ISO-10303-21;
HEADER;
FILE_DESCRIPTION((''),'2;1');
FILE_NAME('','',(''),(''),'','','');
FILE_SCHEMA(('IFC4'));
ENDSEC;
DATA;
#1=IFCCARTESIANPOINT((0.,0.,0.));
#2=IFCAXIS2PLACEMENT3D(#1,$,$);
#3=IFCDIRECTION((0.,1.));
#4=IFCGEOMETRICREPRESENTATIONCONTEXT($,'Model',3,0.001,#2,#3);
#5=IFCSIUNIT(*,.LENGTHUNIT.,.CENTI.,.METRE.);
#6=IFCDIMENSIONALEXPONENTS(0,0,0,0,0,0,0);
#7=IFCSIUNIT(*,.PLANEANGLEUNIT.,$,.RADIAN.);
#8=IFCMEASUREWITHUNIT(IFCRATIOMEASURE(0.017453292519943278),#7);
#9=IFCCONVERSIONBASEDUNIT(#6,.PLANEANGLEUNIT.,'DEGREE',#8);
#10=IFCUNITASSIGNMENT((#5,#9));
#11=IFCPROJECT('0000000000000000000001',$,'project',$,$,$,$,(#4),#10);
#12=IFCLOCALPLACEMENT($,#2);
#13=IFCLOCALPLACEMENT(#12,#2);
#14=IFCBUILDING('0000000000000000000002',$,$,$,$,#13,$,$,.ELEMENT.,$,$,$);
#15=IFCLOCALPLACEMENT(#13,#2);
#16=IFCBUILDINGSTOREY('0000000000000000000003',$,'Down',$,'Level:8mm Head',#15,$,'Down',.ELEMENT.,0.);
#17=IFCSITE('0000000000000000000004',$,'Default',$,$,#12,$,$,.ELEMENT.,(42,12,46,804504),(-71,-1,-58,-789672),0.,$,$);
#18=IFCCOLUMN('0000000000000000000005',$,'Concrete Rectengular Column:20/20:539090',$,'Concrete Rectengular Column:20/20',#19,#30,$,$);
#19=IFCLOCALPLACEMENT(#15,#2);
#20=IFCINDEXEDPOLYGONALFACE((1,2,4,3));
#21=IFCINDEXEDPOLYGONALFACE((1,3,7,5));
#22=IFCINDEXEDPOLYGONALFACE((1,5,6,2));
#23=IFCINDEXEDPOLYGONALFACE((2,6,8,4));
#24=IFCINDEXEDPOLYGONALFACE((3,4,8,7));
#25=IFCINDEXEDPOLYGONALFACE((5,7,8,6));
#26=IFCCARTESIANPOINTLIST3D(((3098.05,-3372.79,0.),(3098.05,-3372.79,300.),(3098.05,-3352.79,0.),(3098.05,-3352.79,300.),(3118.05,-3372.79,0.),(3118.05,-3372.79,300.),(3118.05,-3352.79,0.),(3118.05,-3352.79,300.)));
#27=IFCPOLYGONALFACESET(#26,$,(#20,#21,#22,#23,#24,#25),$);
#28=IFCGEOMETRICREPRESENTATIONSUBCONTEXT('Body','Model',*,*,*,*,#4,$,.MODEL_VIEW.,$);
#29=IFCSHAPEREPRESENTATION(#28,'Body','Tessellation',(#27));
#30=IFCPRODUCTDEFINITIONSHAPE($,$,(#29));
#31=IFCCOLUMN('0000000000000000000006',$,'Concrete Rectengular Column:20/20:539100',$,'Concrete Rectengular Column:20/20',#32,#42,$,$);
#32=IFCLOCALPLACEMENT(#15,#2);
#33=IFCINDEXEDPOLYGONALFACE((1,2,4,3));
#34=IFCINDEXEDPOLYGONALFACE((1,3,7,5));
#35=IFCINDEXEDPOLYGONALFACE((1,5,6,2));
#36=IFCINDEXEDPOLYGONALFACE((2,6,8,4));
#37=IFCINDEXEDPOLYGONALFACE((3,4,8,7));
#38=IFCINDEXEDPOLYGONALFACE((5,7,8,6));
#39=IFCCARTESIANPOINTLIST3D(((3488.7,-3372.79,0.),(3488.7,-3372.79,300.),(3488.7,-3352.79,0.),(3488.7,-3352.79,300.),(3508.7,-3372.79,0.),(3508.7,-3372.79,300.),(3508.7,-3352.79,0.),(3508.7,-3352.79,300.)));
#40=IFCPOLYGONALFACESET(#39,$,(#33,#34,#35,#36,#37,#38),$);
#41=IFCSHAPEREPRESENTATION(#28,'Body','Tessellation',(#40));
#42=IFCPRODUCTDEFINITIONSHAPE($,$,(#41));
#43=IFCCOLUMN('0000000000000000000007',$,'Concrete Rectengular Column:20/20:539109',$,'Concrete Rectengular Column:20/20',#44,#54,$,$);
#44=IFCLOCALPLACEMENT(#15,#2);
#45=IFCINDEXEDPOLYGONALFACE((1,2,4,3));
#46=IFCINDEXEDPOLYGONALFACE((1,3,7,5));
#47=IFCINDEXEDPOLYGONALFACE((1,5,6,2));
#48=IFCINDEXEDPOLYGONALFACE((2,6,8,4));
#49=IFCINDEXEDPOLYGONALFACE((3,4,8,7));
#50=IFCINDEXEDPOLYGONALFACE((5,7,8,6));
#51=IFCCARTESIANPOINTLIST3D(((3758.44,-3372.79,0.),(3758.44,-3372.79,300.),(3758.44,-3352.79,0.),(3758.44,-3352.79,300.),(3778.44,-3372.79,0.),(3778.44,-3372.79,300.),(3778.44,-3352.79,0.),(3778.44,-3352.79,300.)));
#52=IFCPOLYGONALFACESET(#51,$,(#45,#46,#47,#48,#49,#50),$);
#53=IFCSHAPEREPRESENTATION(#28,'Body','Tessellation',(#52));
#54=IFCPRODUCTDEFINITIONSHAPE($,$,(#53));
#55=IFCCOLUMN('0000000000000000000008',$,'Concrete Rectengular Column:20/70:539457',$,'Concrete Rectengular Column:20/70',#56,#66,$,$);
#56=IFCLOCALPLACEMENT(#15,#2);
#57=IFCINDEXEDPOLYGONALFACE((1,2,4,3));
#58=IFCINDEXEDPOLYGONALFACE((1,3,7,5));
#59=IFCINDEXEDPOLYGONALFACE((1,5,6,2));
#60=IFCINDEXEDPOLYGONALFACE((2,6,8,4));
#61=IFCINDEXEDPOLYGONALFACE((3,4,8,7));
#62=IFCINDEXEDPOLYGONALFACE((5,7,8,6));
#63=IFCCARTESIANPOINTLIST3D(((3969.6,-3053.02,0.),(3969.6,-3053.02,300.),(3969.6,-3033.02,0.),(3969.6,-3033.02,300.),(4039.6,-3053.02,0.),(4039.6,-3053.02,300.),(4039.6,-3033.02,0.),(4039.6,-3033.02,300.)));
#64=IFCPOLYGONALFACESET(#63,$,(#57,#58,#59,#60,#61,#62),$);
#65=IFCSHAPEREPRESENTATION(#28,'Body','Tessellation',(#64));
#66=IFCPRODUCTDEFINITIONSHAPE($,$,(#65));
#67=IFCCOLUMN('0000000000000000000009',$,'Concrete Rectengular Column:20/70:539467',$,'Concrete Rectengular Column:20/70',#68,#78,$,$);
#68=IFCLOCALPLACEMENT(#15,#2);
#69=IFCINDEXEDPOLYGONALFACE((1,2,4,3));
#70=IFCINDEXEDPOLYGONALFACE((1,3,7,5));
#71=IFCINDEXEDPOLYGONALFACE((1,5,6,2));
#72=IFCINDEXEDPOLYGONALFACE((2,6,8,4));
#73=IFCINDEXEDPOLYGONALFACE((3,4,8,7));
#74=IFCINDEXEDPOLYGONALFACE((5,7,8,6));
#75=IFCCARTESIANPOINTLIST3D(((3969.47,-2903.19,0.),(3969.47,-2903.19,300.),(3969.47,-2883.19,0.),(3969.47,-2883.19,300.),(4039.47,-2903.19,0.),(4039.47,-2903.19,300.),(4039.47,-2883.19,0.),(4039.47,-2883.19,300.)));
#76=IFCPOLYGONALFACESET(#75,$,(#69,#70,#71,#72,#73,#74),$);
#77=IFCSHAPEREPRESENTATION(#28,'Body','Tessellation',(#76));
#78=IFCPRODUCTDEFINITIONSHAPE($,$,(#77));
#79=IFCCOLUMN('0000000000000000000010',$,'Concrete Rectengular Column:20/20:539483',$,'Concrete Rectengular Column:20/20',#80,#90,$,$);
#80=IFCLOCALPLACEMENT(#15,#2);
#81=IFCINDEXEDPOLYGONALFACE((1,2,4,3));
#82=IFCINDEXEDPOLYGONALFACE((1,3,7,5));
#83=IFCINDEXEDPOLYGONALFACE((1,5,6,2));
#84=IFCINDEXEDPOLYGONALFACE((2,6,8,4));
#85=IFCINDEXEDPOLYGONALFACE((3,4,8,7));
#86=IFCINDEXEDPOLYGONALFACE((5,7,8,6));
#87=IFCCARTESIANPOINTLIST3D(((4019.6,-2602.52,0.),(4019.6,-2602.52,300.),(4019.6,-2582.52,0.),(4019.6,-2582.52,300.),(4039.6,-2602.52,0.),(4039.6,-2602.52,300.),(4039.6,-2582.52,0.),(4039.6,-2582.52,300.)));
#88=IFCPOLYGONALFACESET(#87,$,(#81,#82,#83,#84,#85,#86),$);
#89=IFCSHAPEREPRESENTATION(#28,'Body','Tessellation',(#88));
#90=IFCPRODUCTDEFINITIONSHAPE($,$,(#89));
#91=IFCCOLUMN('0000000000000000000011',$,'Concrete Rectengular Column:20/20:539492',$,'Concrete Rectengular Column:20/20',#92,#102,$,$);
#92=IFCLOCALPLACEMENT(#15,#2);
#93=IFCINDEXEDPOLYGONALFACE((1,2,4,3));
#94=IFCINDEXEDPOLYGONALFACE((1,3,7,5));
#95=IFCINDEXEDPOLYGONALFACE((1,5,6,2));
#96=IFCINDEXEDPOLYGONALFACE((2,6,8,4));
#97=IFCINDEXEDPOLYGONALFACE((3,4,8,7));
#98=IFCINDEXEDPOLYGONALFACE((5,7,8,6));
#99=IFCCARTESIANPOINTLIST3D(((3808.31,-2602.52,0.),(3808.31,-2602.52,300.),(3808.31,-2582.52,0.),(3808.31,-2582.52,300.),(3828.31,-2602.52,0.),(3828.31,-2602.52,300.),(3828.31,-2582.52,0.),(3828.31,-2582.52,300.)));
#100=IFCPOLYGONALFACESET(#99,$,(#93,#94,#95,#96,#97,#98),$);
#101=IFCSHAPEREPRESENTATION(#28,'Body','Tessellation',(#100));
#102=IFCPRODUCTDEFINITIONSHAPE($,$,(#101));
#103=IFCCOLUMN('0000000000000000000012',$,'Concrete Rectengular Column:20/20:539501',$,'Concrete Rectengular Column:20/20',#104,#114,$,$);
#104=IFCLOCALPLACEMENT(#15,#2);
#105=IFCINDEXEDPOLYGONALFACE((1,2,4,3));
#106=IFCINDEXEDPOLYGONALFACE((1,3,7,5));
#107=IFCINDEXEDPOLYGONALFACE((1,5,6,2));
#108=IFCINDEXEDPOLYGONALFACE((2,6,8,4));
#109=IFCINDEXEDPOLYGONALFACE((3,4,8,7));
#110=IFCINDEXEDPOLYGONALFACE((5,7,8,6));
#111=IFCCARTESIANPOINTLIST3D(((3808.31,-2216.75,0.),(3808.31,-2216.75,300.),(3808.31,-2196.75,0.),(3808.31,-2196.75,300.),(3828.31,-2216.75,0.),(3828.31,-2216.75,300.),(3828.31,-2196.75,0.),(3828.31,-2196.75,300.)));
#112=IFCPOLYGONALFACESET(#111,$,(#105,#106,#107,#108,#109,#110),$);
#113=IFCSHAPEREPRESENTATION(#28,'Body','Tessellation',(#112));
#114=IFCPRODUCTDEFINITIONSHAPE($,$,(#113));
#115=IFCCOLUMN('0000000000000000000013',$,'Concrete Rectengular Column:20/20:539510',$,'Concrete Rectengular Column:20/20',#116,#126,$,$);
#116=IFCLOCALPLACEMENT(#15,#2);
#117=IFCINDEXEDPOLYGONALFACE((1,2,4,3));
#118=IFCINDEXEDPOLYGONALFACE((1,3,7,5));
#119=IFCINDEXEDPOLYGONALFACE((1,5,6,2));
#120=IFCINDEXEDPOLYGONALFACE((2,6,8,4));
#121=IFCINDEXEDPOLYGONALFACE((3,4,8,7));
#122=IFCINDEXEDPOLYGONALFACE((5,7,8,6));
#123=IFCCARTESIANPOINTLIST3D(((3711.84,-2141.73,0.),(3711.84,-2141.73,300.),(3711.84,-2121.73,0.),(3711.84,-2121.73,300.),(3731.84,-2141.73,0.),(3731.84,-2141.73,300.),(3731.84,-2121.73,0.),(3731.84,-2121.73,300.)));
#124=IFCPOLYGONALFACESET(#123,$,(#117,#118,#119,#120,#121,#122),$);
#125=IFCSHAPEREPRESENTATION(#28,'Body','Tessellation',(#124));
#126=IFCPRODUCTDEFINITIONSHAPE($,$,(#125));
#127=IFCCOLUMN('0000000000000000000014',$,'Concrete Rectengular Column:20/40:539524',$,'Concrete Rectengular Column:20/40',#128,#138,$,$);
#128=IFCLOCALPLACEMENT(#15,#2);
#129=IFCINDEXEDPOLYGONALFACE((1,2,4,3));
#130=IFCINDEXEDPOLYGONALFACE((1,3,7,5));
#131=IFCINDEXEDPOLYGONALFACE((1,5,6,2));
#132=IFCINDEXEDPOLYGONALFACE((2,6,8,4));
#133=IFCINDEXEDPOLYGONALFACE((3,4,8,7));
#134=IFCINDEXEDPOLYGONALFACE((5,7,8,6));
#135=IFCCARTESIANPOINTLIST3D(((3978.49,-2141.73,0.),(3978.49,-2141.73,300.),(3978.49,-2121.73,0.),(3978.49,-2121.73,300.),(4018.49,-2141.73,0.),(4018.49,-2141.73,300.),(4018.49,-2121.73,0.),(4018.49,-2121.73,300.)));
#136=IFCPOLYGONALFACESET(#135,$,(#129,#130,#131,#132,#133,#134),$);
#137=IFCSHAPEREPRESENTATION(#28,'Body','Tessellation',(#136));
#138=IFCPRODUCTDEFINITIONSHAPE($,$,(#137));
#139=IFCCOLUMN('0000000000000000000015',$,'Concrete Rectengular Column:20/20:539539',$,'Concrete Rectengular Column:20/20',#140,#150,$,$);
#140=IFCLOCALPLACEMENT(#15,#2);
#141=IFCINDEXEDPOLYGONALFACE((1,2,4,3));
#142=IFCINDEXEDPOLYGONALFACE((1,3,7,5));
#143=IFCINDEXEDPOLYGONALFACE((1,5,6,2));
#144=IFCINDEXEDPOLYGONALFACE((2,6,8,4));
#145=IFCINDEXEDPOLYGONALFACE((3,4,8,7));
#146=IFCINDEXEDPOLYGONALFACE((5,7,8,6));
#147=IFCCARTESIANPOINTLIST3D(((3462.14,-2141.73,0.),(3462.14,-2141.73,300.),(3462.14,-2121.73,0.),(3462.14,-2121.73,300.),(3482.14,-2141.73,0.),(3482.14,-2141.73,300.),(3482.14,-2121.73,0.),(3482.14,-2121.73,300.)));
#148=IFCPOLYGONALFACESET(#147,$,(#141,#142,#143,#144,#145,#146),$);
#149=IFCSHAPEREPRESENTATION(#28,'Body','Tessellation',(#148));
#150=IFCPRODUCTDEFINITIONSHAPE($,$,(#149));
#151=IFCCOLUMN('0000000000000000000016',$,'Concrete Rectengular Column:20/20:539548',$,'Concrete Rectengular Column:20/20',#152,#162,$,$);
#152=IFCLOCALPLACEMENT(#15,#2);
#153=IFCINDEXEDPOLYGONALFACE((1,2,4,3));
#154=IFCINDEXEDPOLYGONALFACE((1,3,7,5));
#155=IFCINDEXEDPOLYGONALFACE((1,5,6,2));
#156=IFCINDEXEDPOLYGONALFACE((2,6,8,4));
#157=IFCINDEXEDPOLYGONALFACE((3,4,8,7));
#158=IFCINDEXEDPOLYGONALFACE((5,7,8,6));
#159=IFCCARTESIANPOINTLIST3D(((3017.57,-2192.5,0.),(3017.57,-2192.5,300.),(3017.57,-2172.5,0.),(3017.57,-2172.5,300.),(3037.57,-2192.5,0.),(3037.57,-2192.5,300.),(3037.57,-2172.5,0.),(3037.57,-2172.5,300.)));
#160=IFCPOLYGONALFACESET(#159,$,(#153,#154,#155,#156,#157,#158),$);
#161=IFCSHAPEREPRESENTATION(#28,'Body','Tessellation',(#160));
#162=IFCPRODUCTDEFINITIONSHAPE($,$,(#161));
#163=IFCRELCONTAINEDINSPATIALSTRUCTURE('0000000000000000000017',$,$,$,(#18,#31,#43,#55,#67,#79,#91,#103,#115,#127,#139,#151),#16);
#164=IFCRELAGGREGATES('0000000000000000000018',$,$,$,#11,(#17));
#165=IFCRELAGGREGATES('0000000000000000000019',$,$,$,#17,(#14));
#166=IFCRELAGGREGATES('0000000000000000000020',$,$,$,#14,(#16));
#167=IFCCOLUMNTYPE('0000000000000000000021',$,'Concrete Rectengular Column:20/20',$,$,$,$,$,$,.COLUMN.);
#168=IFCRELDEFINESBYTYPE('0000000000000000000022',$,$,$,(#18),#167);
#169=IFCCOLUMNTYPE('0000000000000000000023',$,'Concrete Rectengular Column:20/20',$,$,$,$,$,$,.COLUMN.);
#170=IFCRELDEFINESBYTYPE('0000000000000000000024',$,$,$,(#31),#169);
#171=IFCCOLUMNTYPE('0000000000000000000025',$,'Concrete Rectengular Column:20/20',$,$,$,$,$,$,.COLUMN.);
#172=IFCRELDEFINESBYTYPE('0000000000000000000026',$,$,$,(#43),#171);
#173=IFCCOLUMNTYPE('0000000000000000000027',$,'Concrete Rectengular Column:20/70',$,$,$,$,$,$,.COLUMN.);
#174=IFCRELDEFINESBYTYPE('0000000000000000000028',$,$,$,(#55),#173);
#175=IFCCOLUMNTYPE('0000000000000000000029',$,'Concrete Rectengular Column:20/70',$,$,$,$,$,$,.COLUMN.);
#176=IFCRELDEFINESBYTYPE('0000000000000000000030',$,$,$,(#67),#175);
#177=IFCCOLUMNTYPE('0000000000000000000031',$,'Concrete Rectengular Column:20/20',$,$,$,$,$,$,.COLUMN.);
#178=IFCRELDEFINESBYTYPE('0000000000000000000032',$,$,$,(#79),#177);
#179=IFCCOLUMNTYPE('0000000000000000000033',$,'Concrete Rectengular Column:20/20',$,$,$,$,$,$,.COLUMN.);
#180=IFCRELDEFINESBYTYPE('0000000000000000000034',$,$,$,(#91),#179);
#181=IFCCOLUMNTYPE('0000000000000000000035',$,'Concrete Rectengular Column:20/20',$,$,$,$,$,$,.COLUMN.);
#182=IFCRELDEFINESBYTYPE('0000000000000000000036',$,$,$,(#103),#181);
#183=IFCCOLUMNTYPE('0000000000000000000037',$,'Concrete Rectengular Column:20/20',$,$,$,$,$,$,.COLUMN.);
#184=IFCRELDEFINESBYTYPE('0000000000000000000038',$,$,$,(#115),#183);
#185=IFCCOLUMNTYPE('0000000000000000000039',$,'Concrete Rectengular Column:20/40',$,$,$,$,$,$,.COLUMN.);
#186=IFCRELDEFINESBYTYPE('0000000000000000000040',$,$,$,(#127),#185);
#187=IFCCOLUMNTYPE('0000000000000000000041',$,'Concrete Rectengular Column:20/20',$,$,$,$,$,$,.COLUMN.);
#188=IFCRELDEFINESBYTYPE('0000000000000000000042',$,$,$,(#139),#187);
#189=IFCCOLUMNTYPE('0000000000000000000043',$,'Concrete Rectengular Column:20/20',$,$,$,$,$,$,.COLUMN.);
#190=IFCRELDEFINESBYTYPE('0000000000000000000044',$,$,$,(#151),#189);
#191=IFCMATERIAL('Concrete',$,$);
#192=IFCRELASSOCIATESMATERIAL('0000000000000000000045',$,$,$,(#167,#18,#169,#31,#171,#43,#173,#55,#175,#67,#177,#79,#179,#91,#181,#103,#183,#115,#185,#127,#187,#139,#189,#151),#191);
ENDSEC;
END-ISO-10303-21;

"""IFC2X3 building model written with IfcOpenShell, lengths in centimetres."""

from ifc_helpers import new_model, entity, si_unit, converted_unit, direction, frame, frame_2d, origin, origin_2d_with_axis, place, context, subcontext, project, spatial, rectangle, extrude, source, transform, mapped, material, type_object, type_shapes, element, save


model = new_model("IFC2X3")

# Units and contexts
model_context = context("Model", 3, precision=0.001, world=origin(), true_north=direction((0.0, 1.0)))
body_context = subcontext(model_context, "Body", "Model", "MODEL_VIEW")
ifc_project = project(units=[si_unit("LENGTHUNIT", "METRE", prefix="CENTI"), converted_unit("PLANEANGLEUNIT", "DEGREE", entity("IfcRatioMeasure", 0.017453292519943278), si_unit("PLANEANGLEUNIT", "RADIAN"), dimensions=[0, 0, 0, 0, 0, 0, 0])], contexts=[model_context])

# Site, building, storey
site_placement = place(None, origin())
site = spatial("IfcSite", under=ifc_project, at=site_placement, Name="Default", CompositionType="ELEMENT", RefLatitude=(42, 12, 46, 804504), RefLongitude=(-71, -1, -58, -789672), RefElevation=0.0)
building_placement = place(site_placement, origin())
building = spatial("IfcBuilding", under=site, at=building_placement, CompositionType="ELEMENT")
storey_placement = place(building_placement, origin())
storey = spatial("IfcBuildingStorey", under=building, at=storey_placement, Name="Down", ObjectType="Level:8mm Head", LongName="Down", CompositionType="ELEMENT", Elevation=0.0)

# Columns
ifc_material = material(Name="Concrete")
column_type_1 = type_object("IfcColumnType", Name="Concrete Rectengular Column:20/20", PredefinedType="COLUMN", material=ifc_material)
shared_shape_1 = source(origin(), body_context, "Body", "SweptSolid", [
    extrude(rectangle(XDim=20.0, YDim=20.0, at=origin_2d_with_axis()), frame((3108.05, -3362.79, 0.0), z_axis=(0.0, 0.0, 1.0), x_axis=(0.0, -1.0, 0.0)), (0.0, 0.0, 1.0), 300.0),
])
type_shapes(column_type_1, [shared_shape_1])
column_1_placement = place(storey_placement, origin())
element("IfcColumn", 1, at=column_1_placement, inside=storey, type_object=column_type_1, material=ifc_material, Name="Concrete Rectengular Column:20/20:539090", ObjectType="Concrete Rectengular Column:20/20", context=body_context, shape_type="MappedRepresentation", body=[
    mapped(shared_shape_1, transform((0.0, 0.0, 0.0), scale=1.0)),
])
column_type_2 = type_object("IfcColumnType", Name="Concrete Rectengular Column:20/20", PredefinedType="COLUMN", material=ifc_material)
shared_shape_2 = source(origin(), body_context, "Body", "SweptSolid", [
    extrude(rectangle(XDim=20.0, YDim=20.0, at=origin_2d_with_axis()), frame((3498.7, -3362.79, 0.0), z_axis=(0.0, 0.0, 1.0), x_axis=(0.0, -1.0, 0.0)), (0.0, 0.0, 1.0), 300.0),
])
type_shapes(column_type_2, [shared_shape_2])
column_2_placement = place(storey_placement, origin())
element("IfcColumn", 2, at=column_2_placement, inside=storey, type_object=column_type_2, material=ifc_material, Name="Concrete Rectengular Column:20/20:539100", ObjectType="Concrete Rectengular Column:20/20", context=body_context, shape_type="MappedRepresentation", body=[
    mapped(shared_shape_2, transform((0.0, 0.0, 0.0), scale=1.0)),
])
column_type_3 = type_object("IfcColumnType", Name="Concrete Rectengular Column:20/20", PredefinedType="COLUMN", material=ifc_material)
shared_shape_3 = source(origin(), body_context, "Body", "SweptSolid", [
    extrude(rectangle(XDim=20.0, YDim=20.0, at=origin_2d_with_axis()), frame((3768.44, -3362.79, 0.0), z_axis=(0.0, 0.0, 1.0), x_axis=(0.0, -1.0, 0.0)), (0.0, 0.0, 1.0), 300.0),
])
type_shapes(column_type_3, [shared_shape_3])
column_3_placement = place(storey_placement, origin())
element("IfcColumn", 3, at=column_3_placement, inside=storey, type_object=column_type_3, material=ifc_material, Name="Concrete Rectengular Column:20/20:539109", ObjectType="Concrete Rectengular Column:20/20", context=body_context, shape_type="MappedRepresentation", body=[
    mapped(shared_shape_3, transform((0.0, 0.0, 0.0), scale=1.0)),
])
column_type_4 = type_object("IfcColumnType", Name="Concrete Rectengular Column:20/70", PredefinedType="COLUMN", material=ifc_material)
shared_shape_4 = source(origin(), body_context, "Body", "SweptSolid", [
    extrude(rectangle(XDim=20.0, YDim=70.0, at=origin_2d_with_axis()), frame((4004.6, -3043.02, 0.0), z_axis=(0.0, 0.0, 1.0), x_axis=(0.0, -1.0, 0.0)), (0.0, 0.0, 1.0), 300.0),
])
type_shapes(column_type_4, [shared_shape_4])
column_4_placement = place(storey_placement, origin())
element("IfcColumn", 4, at=column_4_placement, inside=storey, type_object=column_type_4, material=ifc_material, Name="Concrete Rectengular Column:20/70:539457", ObjectType="Concrete Rectengular Column:20/70", context=body_context, shape_type="MappedRepresentation", body=[
    mapped(shared_shape_4, transform((0.0, 0.0, 0.0), scale=1.0)),
])
column_type_5 = type_object("IfcColumnType", Name="Concrete Rectengular Column:20/70", PredefinedType="COLUMN", material=ifc_material)
shared_shape_5 = source(origin(), body_context, "Body", "SweptSolid", [
    extrude(rectangle(XDim=20.0, YDim=70.0, at=frame_2d((0.0, 0.0), x_axis=(1.0, 0.0))), frame((4004.47, -2893.19, 0.0), z_axis=(0.0, 0.0, 1.0), x_axis=(0.0, -1.0, 0.0)), (0.0, 0.0, 1.0), 300.0),
])
type_shapes(column_type_5, [shared_shape_5])
column_5_placement = place(storey_placement, origin())
element("IfcColumn", 5, at=column_5_placement, inside=storey, type_object=column_type_5, material=ifc_material, Name="Concrete Rectengular Column:20/70:539467", ObjectType="Concrete Rectengular Column:20/70", context=body_context, shape_type="MappedRepresentation", body=[
    mapped(shared_shape_5, transform((0.0, 0.0, 0.0), scale=1.0)),
])
column_type_6 = type_object("IfcColumnType", Name="Concrete Rectengular Column:20/20", PredefinedType="COLUMN", material=ifc_material)
shared_shape_6 = source(origin(), body_context, "Body", "SweptSolid", [
    extrude(rectangle(XDim=20.0, YDim=20.0, at=origin_2d_with_axis()), frame((4029.6, -2592.52, 0.0), z_axis=(0.0, 0.0, 1.0), x_axis=(0.0, -1.0, 0.0)), (0.0, 0.0, 1.0), 300.0),
])
type_shapes(column_type_6, [shared_shape_6])
column_6_placement = place(storey_placement, origin())
element("IfcColumn", 6, at=column_6_placement, inside=storey, type_object=column_type_6, material=ifc_material, Name="Concrete Rectengular Column:20/20:539483", ObjectType="Concrete Rectengular Column:20/20", context=body_context, shape_type="MappedRepresentation", body=[
    mapped(shared_shape_6, transform((0.0, 0.0, 0.0), scale=1.0)),
])
column_type_7 = type_object("IfcColumnType", Name="Concrete Rectengular Column:20/20", PredefinedType="COLUMN", material=ifc_material)
shared_shape_7 = source(origin(), body_context, "Body", "SweptSolid", [
    extrude(rectangle(XDim=20.0, YDim=20.0, at=origin_2d_with_axis()), frame((3818.31, -2592.52, 0.0), z_axis=(0.0, 0.0, 1.0), x_axis=(0.0, -1.0, 0.0)), (0.0, 0.0, 1.0), 300.0),
])
type_shapes(column_type_7, [shared_shape_7])
column_7_placement = place(storey_placement, origin())
element("IfcColumn", 7, at=column_7_placement, inside=storey, type_object=column_type_7, material=ifc_material, Name="Concrete Rectengular Column:20/20:539492", ObjectType="Concrete Rectengular Column:20/20", context=body_context, shape_type="MappedRepresentation", body=[
    mapped(shared_shape_7, transform((0.0, 0.0, 0.0), scale=1.0)),
])
column_type_8 = type_object("IfcColumnType", Name="Concrete Rectengular Column:20/20", PredefinedType="COLUMN", material=ifc_material)
shared_shape_8 = source(origin(), body_context, "Body", "SweptSolid", [
    extrude(rectangle(XDim=20.0, YDim=20.0, at=origin_2d_with_axis()), frame((3818.31, -2206.75, 0.0), z_axis=(0.0, 0.0, 1.0), x_axis=(0.0, -1.0, 0.0)), (0.0, 0.0, 1.0), 300.0),
])
type_shapes(column_type_8, [shared_shape_8])
column_8_placement = place(storey_placement, origin())
element("IfcColumn", 8, at=column_8_placement, inside=storey, type_object=column_type_8, material=ifc_material, Name="Concrete Rectengular Column:20/20:539501", ObjectType="Concrete Rectengular Column:20/20", context=body_context, shape_type="MappedRepresentation", body=[
    mapped(shared_shape_8, transform((0.0, 0.0, 0.0), scale=1.0)),
])
column_type_9 = type_object("IfcColumnType", Name="Concrete Rectengular Column:20/20", PredefinedType="COLUMN", material=ifc_material)
shared_shape_9 = source(origin(), body_context, "Body", "SweptSolid", [
    extrude(rectangle(XDim=20.0, YDim=20.0, at=origin_2d_with_axis()), frame((3721.84, -2131.73, 0.0), z_axis=(0.0, 0.0, 1.0), x_axis=(0.0, -1.0, 0.0)), (0.0, 0.0, 1.0), 300.0),
])
type_shapes(column_type_9, [shared_shape_9])
column_9_placement = place(storey_placement, origin())
element("IfcColumn", 9, at=column_9_placement, inside=storey, type_object=column_type_9, material=ifc_material, Name="Concrete Rectengular Column:20/20:539510", ObjectType="Concrete Rectengular Column:20/20", context=body_context, shape_type="MappedRepresentation", body=[
    mapped(shared_shape_9, transform((0.0, 0.0, 0.0), scale=1.0)),
])
column_type_10 = type_object("IfcColumnType", Name="Concrete Rectengular Column:20/40", PredefinedType="COLUMN", material=ifc_material)
shared_shape_10 = source(origin(), body_context, "Body", "SweptSolid", [
    extrude(rectangle(XDim=20.0, YDim=40.0, at=origin_2d_with_axis()), frame((3998.49, -2131.73, 0.0), z_axis=(0.0, 0.0, 1.0), x_axis=(0.0, -1.0, 0.0)), (0.0, 0.0, 1.0), 300.0),
])
type_shapes(column_type_10, [shared_shape_10])
column_10_placement = place(storey_placement, origin())
element("IfcColumn", 10, at=column_10_placement, inside=storey, type_object=column_type_10, material=ifc_material, Name="Concrete Rectengular Column:20/40:539524", ObjectType="Concrete Rectengular Column:20/40", context=body_context, shape_type="MappedRepresentation", body=[
    mapped(shared_shape_10, transform((0.0, 0.0, 0.0), scale=1.0)),
])
column_type_11 = type_object("IfcColumnType", Name="Concrete Rectengular Column:20/20", PredefinedType="COLUMN", material=ifc_material)
shared_shape_11 = source(origin(), body_context, "Body", "SweptSolid", [
    extrude(rectangle(XDim=20.0, YDim=20.0, at=frame_2d((0.0, 0.0), x_axis=(1.0, 0.0))), frame((3472.14, -2131.73, 0.0), z_axis=(0.0, 0.0, 1.0), x_axis=(0.0, -1.0, 0.0)), (0.0, 0.0, 1.0), 300.0),
])
type_shapes(column_type_11, [shared_shape_11])
column_11_placement = place(storey_placement, origin())
element("IfcColumn", 11, at=column_11_placement, inside=storey, type_object=column_type_11, material=ifc_material, Name="Concrete Rectengular Column:20/20:539539", ObjectType="Concrete Rectengular Column:20/20", context=body_context, shape_type="MappedRepresentation", body=[
    mapped(shared_shape_11, transform((0.0, 0.0, 0.0), scale=1.0)),
])
column_type_12 = type_object("IfcColumnType", Name="Concrete Rectengular Column:20/20", PredefinedType="COLUMN", material=ifc_material)
shared_shape_12 = source(origin(), body_context, "Body", "SweptSolid", [
    extrude(rectangle(XDim=20.0, YDim=20.0, at=origin_2d_with_axis()), frame((3027.57, -2182.5, 0.0), z_axis=(0.0, 0.0, 1.0), x_axis=(0.0, -1.0, 0.0)), (0.0, 0.0, 1.0), 300.0),
])
type_shapes(column_type_12, [shared_shape_12])
column_12_placement = place(storey_placement, origin())
element("IfcColumn", 12, at=column_12_placement, inside=storey, type_object=column_type_12, material=ifc_material, Name="Concrete Rectengular Column:20/20:539548", ObjectType="Concrete Rectengular Column:20/20", context=body_context, shape_type="MappedRepresentation", body=[
    mapped(shared_shape_12, transform((0.0, 0.0, 0.0), scale=1.0)),
])

save(model, "model.ifc")
